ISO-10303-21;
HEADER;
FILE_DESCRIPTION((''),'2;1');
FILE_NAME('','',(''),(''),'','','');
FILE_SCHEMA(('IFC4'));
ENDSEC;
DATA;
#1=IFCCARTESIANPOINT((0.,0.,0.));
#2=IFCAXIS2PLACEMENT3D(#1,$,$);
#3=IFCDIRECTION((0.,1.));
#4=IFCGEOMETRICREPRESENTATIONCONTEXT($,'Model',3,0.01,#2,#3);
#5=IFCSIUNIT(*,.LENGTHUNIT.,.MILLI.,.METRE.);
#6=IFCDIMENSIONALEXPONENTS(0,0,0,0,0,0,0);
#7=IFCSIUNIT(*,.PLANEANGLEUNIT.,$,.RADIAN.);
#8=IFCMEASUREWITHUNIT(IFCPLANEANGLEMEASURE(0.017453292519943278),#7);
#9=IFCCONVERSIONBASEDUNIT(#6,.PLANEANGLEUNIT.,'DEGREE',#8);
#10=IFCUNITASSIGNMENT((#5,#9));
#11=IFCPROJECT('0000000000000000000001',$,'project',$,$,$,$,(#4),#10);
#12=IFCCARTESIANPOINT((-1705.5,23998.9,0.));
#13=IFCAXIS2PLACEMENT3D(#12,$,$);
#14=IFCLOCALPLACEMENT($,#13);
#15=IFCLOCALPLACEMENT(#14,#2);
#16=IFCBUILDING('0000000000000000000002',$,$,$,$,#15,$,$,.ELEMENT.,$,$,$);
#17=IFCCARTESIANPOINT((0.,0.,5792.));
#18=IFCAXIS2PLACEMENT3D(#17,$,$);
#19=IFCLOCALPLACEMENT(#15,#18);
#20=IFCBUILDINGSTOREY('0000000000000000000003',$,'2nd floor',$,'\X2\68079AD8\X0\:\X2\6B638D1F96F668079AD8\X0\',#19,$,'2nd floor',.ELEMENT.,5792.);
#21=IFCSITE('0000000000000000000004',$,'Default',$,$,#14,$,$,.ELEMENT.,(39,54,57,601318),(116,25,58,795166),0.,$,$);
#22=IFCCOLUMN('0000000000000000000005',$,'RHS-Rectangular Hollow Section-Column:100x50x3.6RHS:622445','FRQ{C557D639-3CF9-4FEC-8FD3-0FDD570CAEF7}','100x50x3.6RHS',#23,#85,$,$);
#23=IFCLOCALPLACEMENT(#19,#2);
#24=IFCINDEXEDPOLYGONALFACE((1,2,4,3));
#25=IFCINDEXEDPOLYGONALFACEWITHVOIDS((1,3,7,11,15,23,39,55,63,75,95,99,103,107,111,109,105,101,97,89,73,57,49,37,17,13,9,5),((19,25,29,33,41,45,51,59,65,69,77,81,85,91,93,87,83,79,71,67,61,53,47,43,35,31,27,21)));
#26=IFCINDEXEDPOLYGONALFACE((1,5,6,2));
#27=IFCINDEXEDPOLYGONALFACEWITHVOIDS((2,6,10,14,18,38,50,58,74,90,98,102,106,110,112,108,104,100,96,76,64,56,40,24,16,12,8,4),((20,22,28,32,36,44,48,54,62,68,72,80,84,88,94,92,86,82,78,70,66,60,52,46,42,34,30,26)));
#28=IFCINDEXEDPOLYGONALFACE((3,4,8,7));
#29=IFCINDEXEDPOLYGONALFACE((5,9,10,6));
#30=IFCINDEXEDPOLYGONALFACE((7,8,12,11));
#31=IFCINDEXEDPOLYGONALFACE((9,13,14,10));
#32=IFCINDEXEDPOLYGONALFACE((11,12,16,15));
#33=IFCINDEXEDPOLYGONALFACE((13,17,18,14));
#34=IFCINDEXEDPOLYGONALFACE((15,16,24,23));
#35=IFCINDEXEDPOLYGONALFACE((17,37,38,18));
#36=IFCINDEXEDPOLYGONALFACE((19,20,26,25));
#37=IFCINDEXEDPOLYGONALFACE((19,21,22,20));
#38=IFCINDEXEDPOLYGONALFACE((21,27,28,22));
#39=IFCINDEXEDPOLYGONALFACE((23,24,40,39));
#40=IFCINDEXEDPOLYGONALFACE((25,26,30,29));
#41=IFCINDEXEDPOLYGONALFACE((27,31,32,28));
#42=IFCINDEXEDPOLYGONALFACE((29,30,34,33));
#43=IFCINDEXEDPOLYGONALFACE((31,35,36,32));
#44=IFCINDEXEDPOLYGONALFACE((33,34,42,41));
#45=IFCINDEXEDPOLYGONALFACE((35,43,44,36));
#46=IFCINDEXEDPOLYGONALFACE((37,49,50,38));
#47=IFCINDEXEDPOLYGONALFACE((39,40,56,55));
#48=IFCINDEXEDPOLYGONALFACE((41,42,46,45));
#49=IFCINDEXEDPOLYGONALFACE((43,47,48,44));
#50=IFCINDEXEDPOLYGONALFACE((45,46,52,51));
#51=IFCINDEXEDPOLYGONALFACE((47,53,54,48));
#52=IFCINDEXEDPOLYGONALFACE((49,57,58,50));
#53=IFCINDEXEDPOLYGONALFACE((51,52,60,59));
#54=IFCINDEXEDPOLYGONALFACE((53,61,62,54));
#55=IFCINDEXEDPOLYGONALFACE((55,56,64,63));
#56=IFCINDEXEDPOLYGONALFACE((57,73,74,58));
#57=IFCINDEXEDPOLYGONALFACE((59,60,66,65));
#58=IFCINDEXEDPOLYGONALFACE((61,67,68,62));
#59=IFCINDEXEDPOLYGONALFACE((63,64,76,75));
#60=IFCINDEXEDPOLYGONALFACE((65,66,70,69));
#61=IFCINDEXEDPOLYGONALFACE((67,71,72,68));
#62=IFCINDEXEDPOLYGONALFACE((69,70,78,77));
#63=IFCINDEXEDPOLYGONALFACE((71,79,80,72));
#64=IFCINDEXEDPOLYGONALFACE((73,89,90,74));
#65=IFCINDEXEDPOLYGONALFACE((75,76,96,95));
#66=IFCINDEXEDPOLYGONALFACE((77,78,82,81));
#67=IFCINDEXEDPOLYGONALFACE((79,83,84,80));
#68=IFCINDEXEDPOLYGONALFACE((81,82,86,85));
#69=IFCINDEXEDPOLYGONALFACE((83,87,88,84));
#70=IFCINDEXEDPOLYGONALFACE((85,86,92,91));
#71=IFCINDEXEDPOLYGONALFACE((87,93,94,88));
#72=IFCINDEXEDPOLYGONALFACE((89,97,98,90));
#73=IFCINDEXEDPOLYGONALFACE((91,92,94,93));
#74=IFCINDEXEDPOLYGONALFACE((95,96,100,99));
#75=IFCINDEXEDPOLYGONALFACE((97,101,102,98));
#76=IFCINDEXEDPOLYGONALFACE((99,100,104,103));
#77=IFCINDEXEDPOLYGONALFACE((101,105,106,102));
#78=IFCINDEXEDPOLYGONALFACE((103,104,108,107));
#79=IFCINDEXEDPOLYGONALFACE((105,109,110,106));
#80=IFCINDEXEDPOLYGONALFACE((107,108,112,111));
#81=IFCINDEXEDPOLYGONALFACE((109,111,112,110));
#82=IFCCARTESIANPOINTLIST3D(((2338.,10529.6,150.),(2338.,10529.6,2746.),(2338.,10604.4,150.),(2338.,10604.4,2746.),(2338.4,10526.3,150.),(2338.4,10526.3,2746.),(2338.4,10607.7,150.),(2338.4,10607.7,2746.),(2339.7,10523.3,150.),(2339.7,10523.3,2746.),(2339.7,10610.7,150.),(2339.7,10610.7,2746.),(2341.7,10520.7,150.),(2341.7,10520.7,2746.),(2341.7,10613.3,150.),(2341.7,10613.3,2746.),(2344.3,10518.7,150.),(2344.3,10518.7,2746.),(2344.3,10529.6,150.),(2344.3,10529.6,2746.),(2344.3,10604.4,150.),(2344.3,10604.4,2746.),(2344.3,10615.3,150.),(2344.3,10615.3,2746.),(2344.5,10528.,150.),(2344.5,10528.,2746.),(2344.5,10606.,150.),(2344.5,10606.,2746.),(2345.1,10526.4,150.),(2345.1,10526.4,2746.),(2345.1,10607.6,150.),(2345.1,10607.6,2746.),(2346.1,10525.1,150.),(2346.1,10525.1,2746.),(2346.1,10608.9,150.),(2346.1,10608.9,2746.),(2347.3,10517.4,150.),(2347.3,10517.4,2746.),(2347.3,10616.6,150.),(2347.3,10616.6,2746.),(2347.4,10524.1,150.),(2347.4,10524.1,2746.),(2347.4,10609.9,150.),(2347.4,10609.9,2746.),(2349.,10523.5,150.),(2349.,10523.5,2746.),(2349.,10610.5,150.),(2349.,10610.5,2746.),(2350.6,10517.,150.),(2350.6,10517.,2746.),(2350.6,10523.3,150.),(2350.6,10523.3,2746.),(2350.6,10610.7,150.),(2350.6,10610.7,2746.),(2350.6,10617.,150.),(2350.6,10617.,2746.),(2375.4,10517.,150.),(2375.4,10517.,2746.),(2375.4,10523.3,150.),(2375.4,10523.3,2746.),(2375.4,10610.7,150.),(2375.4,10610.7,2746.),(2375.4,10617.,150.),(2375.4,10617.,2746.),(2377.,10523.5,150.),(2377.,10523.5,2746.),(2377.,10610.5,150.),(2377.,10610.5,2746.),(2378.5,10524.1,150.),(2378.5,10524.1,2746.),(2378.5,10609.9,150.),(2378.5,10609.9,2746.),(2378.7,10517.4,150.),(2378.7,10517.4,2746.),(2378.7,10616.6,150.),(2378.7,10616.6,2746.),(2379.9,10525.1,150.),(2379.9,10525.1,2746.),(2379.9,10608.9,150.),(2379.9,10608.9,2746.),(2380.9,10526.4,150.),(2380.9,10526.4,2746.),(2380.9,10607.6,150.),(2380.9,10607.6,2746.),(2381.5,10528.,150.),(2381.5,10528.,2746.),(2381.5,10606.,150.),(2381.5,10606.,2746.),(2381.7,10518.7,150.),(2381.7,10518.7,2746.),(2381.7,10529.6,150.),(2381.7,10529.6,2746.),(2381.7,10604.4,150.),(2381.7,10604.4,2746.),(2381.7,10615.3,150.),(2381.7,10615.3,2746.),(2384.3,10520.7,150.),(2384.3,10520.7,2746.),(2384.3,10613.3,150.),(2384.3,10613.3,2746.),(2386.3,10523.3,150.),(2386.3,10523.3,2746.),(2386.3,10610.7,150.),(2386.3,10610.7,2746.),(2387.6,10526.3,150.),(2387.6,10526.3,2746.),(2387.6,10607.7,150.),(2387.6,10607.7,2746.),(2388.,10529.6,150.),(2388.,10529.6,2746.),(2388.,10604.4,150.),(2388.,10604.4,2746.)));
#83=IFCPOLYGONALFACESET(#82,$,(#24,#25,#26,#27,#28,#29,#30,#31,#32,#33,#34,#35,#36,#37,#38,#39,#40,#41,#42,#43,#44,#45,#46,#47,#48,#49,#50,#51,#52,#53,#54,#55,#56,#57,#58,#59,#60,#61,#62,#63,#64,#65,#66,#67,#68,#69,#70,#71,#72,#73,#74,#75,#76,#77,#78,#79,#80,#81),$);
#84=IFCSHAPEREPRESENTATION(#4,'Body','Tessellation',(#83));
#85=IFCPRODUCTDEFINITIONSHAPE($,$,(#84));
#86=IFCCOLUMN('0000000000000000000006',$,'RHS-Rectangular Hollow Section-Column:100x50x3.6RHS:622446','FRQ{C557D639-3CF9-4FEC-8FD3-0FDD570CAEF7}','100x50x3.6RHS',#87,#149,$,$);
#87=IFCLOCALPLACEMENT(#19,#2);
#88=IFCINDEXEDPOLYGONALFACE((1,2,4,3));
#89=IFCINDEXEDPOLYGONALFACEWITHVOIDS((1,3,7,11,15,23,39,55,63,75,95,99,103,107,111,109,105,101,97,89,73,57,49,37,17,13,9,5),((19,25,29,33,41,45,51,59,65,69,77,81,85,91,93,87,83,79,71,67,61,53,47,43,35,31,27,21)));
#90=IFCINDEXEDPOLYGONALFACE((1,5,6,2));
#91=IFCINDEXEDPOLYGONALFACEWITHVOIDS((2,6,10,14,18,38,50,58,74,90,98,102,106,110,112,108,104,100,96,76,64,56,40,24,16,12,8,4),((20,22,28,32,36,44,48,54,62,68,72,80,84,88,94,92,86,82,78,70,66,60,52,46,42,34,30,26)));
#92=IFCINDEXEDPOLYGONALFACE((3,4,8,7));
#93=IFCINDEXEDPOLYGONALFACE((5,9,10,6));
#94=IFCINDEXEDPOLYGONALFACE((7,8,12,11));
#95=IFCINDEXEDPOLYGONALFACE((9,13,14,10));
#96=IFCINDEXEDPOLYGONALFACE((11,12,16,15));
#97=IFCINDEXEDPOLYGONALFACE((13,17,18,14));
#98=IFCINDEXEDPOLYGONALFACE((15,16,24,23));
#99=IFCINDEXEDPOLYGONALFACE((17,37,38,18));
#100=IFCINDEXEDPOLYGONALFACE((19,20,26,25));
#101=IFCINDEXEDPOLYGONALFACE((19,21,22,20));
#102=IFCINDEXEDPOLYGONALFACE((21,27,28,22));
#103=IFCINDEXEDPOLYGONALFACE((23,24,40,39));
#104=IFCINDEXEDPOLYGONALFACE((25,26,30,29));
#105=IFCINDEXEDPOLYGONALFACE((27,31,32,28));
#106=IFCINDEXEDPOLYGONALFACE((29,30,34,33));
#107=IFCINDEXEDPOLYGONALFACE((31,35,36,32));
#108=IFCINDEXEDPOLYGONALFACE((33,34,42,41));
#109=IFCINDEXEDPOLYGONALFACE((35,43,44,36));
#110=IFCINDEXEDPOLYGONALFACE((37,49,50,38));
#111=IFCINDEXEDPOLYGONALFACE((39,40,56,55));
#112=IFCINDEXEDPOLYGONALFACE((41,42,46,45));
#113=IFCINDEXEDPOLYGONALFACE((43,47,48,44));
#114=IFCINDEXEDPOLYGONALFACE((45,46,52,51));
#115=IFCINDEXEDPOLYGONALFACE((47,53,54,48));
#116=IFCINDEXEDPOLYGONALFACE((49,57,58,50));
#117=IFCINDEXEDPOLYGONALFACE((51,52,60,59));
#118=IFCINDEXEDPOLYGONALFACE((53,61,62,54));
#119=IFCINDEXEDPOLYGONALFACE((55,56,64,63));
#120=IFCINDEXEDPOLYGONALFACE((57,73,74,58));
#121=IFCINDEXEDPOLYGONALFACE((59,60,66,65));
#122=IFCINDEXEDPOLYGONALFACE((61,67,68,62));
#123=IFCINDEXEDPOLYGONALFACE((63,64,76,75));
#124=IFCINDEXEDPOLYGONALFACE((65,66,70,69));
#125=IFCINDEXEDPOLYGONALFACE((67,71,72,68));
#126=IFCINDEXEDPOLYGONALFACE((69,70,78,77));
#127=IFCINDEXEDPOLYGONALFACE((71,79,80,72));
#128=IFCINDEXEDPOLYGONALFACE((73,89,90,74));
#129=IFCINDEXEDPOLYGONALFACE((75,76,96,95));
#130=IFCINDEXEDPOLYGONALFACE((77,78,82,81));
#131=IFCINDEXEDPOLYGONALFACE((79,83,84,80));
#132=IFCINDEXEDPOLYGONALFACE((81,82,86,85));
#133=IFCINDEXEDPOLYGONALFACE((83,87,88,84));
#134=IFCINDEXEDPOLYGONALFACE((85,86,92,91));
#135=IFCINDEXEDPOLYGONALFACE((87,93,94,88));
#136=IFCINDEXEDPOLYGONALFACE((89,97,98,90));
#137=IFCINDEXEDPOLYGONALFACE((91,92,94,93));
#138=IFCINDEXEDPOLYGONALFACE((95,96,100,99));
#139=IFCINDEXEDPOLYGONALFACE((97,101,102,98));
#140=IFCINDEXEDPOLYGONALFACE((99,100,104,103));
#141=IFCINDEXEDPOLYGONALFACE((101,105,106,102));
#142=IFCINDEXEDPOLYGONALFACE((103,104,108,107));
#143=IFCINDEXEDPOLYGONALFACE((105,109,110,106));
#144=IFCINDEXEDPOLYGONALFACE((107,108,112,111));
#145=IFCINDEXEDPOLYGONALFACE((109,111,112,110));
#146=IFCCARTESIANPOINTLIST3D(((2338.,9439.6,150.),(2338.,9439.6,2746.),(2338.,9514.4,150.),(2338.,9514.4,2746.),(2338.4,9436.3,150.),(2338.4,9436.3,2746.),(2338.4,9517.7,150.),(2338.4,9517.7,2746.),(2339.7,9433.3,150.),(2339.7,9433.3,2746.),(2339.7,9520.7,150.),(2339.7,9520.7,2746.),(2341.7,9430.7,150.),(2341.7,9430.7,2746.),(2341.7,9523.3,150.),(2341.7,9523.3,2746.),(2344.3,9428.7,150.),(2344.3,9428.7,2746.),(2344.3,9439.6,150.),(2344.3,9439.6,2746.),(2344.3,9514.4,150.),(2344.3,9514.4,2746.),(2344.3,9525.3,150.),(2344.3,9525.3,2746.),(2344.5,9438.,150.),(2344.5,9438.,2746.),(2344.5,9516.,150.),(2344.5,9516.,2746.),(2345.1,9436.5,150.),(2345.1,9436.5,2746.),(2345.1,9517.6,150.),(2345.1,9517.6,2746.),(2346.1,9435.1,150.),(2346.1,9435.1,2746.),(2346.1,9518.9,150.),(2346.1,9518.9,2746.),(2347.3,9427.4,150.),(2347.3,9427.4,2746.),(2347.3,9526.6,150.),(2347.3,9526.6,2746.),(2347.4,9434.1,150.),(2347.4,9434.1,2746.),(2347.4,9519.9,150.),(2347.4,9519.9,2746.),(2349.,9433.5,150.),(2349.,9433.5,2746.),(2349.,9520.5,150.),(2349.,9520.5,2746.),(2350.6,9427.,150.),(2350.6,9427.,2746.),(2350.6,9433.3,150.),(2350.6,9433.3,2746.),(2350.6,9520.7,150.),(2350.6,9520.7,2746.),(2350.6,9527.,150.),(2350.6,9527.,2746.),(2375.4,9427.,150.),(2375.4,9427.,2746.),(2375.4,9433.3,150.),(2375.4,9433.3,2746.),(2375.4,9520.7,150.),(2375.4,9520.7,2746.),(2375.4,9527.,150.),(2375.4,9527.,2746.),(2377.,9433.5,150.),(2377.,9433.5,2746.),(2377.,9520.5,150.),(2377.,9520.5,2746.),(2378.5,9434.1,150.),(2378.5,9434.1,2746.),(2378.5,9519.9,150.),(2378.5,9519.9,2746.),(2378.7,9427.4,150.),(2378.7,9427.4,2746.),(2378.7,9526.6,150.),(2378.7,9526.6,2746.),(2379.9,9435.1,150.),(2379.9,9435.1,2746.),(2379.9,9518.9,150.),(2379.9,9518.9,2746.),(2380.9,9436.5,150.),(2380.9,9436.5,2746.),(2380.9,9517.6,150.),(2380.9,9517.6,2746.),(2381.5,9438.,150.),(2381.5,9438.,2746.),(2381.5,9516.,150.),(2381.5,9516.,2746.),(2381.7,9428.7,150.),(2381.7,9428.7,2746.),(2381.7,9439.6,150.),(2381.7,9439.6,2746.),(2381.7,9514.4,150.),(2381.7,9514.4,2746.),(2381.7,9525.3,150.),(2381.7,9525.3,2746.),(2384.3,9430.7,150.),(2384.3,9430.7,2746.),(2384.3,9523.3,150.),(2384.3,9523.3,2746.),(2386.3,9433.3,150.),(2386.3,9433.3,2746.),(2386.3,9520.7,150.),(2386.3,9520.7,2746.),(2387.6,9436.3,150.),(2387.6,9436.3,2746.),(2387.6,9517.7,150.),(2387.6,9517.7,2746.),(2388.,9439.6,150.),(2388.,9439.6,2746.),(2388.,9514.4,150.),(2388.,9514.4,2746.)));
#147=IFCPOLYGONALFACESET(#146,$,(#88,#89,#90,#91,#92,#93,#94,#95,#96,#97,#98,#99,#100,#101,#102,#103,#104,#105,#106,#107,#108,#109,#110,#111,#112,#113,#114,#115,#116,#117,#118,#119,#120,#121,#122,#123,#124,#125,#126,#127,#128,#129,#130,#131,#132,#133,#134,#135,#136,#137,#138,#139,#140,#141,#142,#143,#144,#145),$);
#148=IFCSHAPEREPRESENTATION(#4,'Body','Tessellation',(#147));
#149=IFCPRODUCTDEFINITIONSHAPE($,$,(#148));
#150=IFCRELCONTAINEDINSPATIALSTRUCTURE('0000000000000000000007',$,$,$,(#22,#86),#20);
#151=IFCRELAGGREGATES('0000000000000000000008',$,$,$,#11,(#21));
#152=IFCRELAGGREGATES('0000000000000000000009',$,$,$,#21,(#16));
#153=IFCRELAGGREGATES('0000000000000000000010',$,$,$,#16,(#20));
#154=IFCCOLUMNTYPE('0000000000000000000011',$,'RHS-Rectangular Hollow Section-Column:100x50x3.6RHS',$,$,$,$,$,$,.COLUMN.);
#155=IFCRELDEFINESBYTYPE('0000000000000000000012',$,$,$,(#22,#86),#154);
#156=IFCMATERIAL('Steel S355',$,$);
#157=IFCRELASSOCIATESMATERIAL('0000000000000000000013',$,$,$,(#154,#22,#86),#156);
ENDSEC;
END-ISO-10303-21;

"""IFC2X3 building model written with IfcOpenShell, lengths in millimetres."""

from ifc_helpers import new_model, entity, si_unit, converted_unit, direction, frame, origin, origin_2d, place, context, project, spatial, hollow_rectangle, extrude, clip, halfspace, material, type_object, element, save


model = new_model("IFC2X3")

# Units and contexts
model_context = context("Model", 3, precision=0.01, world=origin(), true_north=direction((0.0, 1.0)))
ifc_project = project(units=[si_unit("LENGTHUNIT", "METRE", prefix="MILLI"), converted_unit("PLANEANGLEUNIT", "DEGREE", entity("IfcPlaneAngleMeasure", 0.017453292519943278), si_unit("PLANEANGLEUNIT", "RADIAN"), dimensions=[0, 0, 0, 0, 0, 0, 0])], contexts=[model_context])

# Site, building, storey
site_placement = place(None, frame((-1705.5, 23998.9, 0.0)))
site = spatial("IfcSite", under=ifc_project, at=site_placement, Name="Default", CompositionType="ELEMENT", RefLatitude=(39, 54, 57, 601318), RefLongitude=(116, 25, 58, 795166), RefElevation=0.0)
building_placement = place(site_placement, origin())
building = spatial("IfcBuilding", under=site, at=building_placement, CompositionType="ELEMENT")
storey_placement = place(building_placement, frame((0.0, 0.0, 5792.0)))
storey = spatial("IfcBuildingStorey", under=building, at=storey_placement, Name="2nd floor", ObjectType="标高:正负零标高", LongName="2nd floor", CompositionType="ELEMENT", Elevation=5792.0)

# Columns
ifc_material_1 = material(Name="Steel S355")
column_type_1 = type_object("IfcColumnType", Name="RHS-Rectangular Hollow Section-Column:100x50x3.6RHS", PredefinedType="COLUMN", material=ifc_material_1)
column_1_placement = place(storey_placement, frame((2363.0, 10567.0, 2746.0), z_axis=(0.0, 0.0, 1.0), x_axis=(-1.0, 0.0, 0.0)))
element("IfcColumn", 1, at=column_1_placement, inside=storey, type_object=column_type_1, material=ifc_material_1, Name="RHS-Rectangular Hollow Section-Column:100x50x3.6RHS:622445", Description="FRQ{C557D639-3CF9-4FEC-8FD3-0FDD570CAEF7}", ObjectType="100x50x3.6RHS", context=model_context, shape_type="Clipping", body=[
    clip(extrude(hollow_rectangle(XDim=50.0, YDim=100.0, WallThickness=6.3, InnerFilletRadius=6.3, OuterFilletRadius=12.6, at=origin_2d()), origin(), (0.0, 0.0, -1.0), 2651.9), halfspace(frame((2363.0, 10567.0, -2596.0), z_axis=(0.0, 0.0, 1.0), x_axis=(-1.0, 0.0, 0.0)), True)),
])
column_2_placement = place(storey_placement, frame((2363.0, 9477.0, 2746.0), z_axis=(0.0, 0.0, 1.0), x_axis=(-1.0, 0.0, 0.0)))
element("IfcColumn", 2, at=column_2_placement, inside=storey, type_object=column_type_1, material=ifc_material_1, Name="RHS-Rectangular Hollow Section-Column:100x50x3.6RHS:622446", Description="FRQ{C557D639-3CF9-4FEC-8FD3-0FDD570CAEF7}", ObjectType="100x50x3.6RHS", context=model_context, shape_type="Clipping", body=[
    clip(extrude(hollow_rectangle(XDim=50.0, YDim=100.0, WallThickness=6.3, InnerFilletRadius=6.3, OuterFilletRadius=12.6, at=origin_2d()), origin(), (0.0, 0.0, -1.0), 2651.9), halfspace(frame((2363.0, 9477.0, -2596.0), z_axis=(0.0, 0.0, 1.0), x_axis=(-1.0, 0.0, 0.0)), True)),
])

save(model, "model.ifc")
